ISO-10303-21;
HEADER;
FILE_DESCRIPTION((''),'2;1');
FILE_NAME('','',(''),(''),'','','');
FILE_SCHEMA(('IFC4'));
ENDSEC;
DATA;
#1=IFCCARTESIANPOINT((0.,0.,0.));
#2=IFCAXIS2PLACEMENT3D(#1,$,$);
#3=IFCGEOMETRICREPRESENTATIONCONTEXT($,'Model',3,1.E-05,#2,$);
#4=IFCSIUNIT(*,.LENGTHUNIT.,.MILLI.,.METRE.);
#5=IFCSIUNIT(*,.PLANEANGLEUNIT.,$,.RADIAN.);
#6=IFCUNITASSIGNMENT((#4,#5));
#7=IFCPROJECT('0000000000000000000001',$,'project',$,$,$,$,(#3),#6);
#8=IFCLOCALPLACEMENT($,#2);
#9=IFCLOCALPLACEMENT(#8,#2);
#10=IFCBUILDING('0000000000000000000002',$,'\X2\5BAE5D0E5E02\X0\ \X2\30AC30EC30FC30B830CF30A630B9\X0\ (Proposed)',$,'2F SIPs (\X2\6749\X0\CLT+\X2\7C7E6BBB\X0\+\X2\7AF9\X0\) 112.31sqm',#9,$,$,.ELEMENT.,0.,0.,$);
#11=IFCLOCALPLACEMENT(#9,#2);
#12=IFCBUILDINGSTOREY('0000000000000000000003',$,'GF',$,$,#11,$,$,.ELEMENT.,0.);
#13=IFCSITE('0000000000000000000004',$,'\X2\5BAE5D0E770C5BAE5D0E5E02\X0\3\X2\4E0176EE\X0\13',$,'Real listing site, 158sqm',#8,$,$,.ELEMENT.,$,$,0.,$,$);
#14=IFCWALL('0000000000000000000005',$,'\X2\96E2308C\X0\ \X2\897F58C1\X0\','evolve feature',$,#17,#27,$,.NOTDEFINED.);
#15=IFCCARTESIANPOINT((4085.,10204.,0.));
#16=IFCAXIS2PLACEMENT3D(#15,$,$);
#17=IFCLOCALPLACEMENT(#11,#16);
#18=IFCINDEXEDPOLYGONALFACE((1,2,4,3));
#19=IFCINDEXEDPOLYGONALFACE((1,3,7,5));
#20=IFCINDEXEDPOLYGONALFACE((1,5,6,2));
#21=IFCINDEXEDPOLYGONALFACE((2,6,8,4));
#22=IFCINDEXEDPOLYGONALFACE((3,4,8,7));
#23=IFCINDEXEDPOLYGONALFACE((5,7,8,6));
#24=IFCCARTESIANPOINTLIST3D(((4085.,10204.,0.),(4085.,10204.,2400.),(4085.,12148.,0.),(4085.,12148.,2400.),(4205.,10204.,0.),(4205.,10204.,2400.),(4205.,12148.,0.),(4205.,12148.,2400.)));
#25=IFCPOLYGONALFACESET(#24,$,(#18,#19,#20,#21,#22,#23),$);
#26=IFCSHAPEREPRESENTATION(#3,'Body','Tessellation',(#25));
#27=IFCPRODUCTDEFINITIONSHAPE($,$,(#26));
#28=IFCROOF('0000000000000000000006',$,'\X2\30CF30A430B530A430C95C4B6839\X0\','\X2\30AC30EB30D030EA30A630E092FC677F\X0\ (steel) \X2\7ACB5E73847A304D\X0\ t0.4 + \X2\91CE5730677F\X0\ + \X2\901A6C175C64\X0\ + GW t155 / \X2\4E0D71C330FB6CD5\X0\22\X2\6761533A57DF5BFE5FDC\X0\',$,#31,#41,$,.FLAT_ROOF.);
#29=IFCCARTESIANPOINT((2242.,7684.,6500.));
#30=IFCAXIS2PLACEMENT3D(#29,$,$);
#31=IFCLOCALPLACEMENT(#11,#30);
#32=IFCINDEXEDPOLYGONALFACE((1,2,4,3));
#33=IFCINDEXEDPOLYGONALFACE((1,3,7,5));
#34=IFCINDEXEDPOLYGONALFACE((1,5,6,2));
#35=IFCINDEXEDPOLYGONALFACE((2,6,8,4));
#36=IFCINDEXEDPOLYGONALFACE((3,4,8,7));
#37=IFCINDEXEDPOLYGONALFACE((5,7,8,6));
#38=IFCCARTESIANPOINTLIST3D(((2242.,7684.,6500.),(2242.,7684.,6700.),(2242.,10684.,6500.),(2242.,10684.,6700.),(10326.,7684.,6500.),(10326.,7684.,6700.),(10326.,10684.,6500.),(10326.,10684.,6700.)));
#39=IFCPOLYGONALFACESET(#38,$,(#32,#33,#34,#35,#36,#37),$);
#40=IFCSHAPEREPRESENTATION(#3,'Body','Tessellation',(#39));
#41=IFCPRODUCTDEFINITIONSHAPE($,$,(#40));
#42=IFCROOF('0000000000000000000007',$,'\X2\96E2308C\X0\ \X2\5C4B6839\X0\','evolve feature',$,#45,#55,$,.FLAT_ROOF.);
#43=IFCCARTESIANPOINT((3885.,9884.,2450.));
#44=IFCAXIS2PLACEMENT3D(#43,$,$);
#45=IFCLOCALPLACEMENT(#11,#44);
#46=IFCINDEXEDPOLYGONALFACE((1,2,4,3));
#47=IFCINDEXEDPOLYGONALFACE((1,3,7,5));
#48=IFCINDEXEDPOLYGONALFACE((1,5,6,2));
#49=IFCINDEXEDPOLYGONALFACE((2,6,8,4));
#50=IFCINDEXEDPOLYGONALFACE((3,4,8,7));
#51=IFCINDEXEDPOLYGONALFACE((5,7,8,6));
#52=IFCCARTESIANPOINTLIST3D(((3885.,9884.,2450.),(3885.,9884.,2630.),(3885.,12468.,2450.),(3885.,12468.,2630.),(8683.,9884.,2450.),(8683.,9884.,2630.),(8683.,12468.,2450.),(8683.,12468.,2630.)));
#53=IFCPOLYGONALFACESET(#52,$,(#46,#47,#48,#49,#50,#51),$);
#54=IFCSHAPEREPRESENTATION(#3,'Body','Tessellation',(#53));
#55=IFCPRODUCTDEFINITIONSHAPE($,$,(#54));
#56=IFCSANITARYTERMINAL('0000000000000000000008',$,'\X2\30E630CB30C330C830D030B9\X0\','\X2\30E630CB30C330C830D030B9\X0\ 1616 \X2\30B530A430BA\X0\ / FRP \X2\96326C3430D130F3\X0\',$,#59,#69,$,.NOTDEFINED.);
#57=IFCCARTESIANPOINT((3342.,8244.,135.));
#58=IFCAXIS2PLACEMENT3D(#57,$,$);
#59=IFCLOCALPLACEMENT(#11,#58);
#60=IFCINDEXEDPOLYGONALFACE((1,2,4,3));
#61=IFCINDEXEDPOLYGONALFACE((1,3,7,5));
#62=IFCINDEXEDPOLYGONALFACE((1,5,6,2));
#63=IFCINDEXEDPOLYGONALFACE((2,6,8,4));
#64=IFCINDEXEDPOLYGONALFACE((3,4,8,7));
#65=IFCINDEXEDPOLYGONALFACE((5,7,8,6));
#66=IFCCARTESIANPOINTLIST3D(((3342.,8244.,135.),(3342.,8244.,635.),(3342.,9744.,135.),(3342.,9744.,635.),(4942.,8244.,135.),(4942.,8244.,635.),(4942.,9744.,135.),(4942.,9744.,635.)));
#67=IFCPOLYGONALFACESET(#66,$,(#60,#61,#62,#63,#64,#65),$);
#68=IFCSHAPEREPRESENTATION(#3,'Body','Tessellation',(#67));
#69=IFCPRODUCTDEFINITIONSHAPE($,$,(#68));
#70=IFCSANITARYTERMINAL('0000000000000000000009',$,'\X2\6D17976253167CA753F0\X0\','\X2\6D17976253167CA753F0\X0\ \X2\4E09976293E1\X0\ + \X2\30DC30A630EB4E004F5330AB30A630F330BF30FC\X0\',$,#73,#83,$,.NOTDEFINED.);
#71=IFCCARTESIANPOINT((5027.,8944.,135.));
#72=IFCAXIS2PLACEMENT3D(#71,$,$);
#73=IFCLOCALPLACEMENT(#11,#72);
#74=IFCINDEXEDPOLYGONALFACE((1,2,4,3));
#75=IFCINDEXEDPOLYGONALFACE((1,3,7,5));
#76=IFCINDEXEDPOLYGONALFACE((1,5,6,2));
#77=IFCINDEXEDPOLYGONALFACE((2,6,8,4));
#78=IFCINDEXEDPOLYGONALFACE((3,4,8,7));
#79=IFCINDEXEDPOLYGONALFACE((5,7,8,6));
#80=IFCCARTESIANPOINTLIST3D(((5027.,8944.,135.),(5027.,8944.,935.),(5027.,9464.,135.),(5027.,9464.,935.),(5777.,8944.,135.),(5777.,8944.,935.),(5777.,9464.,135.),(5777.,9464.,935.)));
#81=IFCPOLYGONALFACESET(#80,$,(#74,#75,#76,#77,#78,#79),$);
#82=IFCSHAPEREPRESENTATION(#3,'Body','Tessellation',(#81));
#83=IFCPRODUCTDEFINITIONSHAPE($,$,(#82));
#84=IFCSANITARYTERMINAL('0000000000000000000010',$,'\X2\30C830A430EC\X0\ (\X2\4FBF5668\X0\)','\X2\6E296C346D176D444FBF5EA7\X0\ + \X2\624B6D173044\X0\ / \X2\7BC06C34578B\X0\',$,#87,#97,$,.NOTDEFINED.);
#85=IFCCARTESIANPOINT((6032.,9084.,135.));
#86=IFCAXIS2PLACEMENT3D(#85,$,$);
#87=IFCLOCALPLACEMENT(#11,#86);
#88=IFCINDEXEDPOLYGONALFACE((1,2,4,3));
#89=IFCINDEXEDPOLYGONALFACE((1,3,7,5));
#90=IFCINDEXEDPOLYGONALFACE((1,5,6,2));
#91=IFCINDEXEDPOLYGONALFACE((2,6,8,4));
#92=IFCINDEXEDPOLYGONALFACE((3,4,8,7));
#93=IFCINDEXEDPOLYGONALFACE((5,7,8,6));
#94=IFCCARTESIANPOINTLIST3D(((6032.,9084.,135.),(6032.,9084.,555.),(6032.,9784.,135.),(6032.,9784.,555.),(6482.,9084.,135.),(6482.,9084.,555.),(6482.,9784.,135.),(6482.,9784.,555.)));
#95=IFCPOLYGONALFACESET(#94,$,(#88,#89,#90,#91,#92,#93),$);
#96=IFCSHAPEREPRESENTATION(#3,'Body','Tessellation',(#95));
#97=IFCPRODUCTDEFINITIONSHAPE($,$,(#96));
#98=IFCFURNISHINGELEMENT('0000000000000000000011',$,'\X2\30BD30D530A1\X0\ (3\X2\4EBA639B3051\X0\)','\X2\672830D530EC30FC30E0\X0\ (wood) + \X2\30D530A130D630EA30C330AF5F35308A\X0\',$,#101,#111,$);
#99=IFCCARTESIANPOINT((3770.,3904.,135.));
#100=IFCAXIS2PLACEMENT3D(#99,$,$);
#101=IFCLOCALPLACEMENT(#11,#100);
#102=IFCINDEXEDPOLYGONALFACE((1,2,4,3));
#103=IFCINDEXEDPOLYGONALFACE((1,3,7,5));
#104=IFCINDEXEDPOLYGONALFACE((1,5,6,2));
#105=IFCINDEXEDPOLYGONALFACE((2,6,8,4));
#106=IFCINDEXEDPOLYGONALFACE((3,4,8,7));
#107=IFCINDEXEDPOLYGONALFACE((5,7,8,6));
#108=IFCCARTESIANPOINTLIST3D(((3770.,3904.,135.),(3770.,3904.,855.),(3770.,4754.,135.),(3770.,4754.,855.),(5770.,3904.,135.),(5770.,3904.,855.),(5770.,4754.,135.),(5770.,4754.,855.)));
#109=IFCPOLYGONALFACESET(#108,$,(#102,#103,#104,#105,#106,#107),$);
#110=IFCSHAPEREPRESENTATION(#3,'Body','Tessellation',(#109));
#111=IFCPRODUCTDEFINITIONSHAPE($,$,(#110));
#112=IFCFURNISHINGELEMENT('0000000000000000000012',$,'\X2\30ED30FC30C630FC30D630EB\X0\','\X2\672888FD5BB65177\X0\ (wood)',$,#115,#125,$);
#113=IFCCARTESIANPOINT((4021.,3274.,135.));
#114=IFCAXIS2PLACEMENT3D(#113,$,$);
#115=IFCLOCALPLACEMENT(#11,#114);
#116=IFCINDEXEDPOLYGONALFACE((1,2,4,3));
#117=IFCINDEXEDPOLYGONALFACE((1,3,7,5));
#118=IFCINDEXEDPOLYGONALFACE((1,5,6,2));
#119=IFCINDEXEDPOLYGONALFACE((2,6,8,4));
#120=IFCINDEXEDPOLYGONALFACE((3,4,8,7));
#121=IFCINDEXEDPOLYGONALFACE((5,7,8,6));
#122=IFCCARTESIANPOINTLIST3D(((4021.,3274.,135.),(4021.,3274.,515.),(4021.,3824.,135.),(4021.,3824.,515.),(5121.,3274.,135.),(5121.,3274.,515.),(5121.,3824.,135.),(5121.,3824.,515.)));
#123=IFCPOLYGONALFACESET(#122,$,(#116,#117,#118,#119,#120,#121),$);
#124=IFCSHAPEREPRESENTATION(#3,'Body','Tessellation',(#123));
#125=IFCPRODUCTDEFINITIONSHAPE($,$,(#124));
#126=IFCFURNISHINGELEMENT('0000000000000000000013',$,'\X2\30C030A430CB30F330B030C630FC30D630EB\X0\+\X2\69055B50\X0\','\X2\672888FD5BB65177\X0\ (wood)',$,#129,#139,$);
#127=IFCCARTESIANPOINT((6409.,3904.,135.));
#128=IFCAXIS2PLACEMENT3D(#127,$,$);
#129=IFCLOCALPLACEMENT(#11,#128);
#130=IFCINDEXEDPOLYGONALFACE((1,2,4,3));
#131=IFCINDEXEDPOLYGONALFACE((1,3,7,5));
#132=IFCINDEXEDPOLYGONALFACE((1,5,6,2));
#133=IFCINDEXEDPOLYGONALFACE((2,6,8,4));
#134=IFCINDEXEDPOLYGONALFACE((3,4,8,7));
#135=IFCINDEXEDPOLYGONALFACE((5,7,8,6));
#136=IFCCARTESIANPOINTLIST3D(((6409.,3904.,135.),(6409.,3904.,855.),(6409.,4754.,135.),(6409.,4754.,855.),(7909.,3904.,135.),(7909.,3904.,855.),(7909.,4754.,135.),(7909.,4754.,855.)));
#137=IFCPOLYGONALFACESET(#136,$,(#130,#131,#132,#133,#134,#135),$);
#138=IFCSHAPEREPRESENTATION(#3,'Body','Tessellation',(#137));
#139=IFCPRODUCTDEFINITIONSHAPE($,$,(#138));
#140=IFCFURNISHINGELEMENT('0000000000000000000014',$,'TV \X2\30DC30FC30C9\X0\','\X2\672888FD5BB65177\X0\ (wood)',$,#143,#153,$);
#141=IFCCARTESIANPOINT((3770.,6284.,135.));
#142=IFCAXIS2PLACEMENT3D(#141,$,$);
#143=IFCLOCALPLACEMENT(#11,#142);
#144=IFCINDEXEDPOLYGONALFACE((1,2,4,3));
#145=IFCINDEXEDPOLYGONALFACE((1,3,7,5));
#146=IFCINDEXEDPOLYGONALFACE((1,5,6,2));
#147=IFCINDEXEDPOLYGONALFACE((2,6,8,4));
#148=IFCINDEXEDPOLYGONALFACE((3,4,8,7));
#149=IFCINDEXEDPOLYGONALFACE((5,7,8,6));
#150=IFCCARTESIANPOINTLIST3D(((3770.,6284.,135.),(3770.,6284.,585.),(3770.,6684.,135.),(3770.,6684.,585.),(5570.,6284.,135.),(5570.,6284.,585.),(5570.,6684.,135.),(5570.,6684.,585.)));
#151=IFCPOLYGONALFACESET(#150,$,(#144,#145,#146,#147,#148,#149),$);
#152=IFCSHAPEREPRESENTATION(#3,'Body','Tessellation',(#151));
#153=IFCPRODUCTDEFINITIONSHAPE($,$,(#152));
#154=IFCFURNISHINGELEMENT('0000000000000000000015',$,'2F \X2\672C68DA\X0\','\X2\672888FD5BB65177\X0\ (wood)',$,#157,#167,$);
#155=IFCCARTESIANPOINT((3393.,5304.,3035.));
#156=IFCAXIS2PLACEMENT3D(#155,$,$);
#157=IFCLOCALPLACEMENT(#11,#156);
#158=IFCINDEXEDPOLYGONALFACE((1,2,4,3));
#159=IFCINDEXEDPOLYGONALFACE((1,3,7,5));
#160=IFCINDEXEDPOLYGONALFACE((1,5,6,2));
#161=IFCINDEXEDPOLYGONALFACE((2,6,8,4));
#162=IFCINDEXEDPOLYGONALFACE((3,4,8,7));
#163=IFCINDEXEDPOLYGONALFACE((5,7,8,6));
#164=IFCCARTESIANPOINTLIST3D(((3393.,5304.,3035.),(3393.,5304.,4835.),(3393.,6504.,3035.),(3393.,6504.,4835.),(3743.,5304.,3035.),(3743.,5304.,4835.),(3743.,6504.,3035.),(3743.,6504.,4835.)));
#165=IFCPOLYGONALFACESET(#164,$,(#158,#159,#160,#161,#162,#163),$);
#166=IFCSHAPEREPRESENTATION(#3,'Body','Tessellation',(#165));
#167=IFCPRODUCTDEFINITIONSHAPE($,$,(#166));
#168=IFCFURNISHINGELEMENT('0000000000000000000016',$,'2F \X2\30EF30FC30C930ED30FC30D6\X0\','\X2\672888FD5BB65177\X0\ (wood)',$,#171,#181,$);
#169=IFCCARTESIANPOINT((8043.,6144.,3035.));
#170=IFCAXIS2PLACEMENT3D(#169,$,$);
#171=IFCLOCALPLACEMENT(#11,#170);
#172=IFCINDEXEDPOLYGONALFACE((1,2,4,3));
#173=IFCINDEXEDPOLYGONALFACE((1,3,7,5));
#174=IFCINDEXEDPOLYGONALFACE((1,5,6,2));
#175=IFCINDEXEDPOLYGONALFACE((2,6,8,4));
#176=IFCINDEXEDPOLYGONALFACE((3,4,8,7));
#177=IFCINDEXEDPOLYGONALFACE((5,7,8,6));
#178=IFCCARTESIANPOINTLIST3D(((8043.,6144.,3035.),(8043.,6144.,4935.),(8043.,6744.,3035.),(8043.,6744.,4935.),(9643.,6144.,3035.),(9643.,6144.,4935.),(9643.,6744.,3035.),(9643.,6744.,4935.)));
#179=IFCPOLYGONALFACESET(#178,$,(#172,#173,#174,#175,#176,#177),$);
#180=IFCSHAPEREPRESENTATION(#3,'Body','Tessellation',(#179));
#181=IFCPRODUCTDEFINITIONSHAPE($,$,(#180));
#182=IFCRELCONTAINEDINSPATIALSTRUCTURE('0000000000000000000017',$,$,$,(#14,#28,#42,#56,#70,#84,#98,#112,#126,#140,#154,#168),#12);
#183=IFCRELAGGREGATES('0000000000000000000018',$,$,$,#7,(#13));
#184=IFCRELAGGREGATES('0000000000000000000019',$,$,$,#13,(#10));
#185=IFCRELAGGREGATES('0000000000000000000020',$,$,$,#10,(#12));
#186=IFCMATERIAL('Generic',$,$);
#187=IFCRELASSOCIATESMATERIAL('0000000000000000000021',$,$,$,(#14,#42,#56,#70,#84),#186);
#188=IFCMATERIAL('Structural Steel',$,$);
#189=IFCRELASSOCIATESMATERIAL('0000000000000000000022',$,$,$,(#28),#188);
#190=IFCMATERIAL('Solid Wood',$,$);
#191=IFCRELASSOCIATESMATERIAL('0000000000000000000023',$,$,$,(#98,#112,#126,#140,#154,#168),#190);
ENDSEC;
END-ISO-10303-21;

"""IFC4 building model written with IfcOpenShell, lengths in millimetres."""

from ifc_helpers import new_model, si_unit, frame, frame_2d, origin, place, context, project, spatial, rectangle, extrude, material, element, save


model = new_model("IFC4")

# Units and contexts
model_context = context("Model", 3, precision=1e-05, world=origin())
ifc_project = project(units=[si_unit("LENGTHUNIT", "METRE", prefix="MILLI"), si_unit("PLANEANGLEUNIT", "RADIAN")], contexts=[model_context])

# Site, building, storey
site_placement = place(None, origin())
site = spatial("IfcSite", under=ifc_project, at=site_placement, Name="宮崎県宮崎市3丁目13", ObjectType="Real listing site, 158sqm", CompositionType="ELEMENT", RefElevation=0.0)
building_placement = place(site_placement, origin())
building = spatial("IfcBuilding", under=site, at=building_placement, Name="宮崎市 ガレージハウス (Proposed)", ObjectType="2F SIPs (杉CLT+籾殻+竹) 112.31sqm", CompositionType="ELEMENT", ElevationOfRefHeight=0.0, ElevationOfTerrain=0.0)
storey_placement = place(building_placement, origin())
storey = spatial("IfcBuildingStorey", under=building, at=storey_placement, Name="GF", CompositionType="ELEMENT", Elevation=0.0)

# Shared definitions
ifc_material_1 = material(Name="Generic")

# Shared definitions
ifc_material_2 = material(Name="Solid Wood")

# Wall
wall_1_placement = place(storey_placement, frame((4085.0, 10204.0, 0.0)))
element("IfcWall", 1, at=wall_1_placement, inside=storey, material=ifc_material_1, Name="離れ 西壁", Description="evolve feature", PredefinedType="NOTDEFINED", context=model_context, shape_type="SweptSolid", body=[
    extrude(rectangle(XDim=120.0, YDim=1944.0, at=frame_2d((60.0, 972.0))), frame((4085.0, 10204.0, 0.0)), (0.0, 0.0, 1.0), 2400.0),
])

# Roofs
ifc_material_3 = material(Name="Structural Steel")
roof_1_placement = place(storey_placement, frame((2242.0, 7684.0, 6500.0)))
element("IfcRoof", 2, at=roof_1_placement, inside=storey, material=ifc_material_3, Name="ハイサイド屋根", Description="ガルバリウム鋼板 (steel) 立平葺き t0.4 + 野地板 + 通気層 + GW t155 / 不燃・法22条区域対応", PredefinedType="FLAT_ROOF", context=model_context, shape_type="SweptSolid", body=[
    extrude(rectangle(XDim=8084.0, YDim=3000.0, at=frame_2d((4042.0, 1500.0))), frame((2242.0, 7684.0, 6500.0)), (0.0, 0.0, 1.0), 200.0),
])
roof_2_placement = place(storey_placement, frame((3885.0, 9884.0, 2450.0)))
element("IfcRoof", 3, at=roof_2_placement, inside=storey, material=ifc_material_1, Name="離れ 屋根", Description="evolve feature", PredefinedType="FLAT_ROOF", context=model_context, shape_type="SweptSolid", body=[
    extrude(rectangle(XDim=4798.0, YDim=2584.0, at=frame_2d((2399.0, 1292.0))), frame((3885.0, 9884.0, 2450.0)), (0.0, 0.0, 1.0), 180.0),
])

# Sanitary terminals
sanitary_terminal_1_placement = place(storey_placement, frame((3342.0, 8244.0, 135.0)))
element("IfcSanitaryTerminal", 4, at=sanitary_terminal_1_placement, inside=storey, material=ifc_material_1, Name="ユニットバス", Description="ユニットバス 1616 サイズ / FRP 防水パン", PredefinedType="NOTDEFINED", context=model_context, shape_type="SweptSolid", body=[
    extrude(rectangle(XDim=1600.0, YDim=1500.0, at=frame_2d((800.0, 750.0))), frame((3342.0, 8244.0, 135.0)), (0.0, 0.0, 1.0), 500.0),
])
sanitary_terminal_2_placement = place(storey_placement, frame((5027.0, 8944.0, 135.0)))
element("IfcSanitaryTerminal", 5, at=sanitary_terminal_2_placement, inside=storey, material=ifc_material_1, Name="洗面化粧台", Description="洗面化粧台 三面鏡 + ボウル一体カウンター", PredefinedType="NOTDEFINED", context=model_context, shape_type="SweptSolid", body=[
    extrude(rectangle(XDim=750.0, YDim=520.0, at=frame_2d((375.0, 260.0))), frame((5027.0, 8944.0, 135.0)), (0.0, 0.0, 1.0), 800.0),
])
sanitary_terminal_3_placement = place(storey_placement, frame((6032.0, 9084.0, 135.0)))
element("IfcSanitaryTerminal", 6, at=sanitary_terminal_3_placement, inside=storey, material=ifc_material_1, Name="トイレ (便器)", Description="温水洗浄便座 + 手洗い / 節水型", PredefinedType="NOTDEFINED", context=model_context, shape_type="SweptSolid", body=[
    extrude(rectangle(XDim=450.0, YDim=700.0, at=frame_2d((225.0, 350.0))), frame((6032.0, 9084.0, 135.0)), (0.0, 0.0, 1.0), 420.0),
])

# Furnishing elements
furnishing_1_placement = place(storey_placement, frame((3770.0, 3904.0, 135.0)))
element("IfcFurnishingElement", 7, at=furnishing_1_placement, inside=storey, material=ifc_material_2, Name="ソファ (3人掛け)", Description="木フレーム (wood) + ファブリック張り", context=model_context, shape_type="SweptSolid", body=[
    extrude(rectangle(XDim=2000.0, YDim=850.0, at=frame_2d((1000.0, 425.0))), frame((3770.0, 3904.0, 135.0)), (0.0, 0.0, 1.0), 720.0),
])
furnishing_2_placement = place(storey_placement, frame((4021.0, 3274.0, 135.0)))
element("IfcFurnishingElement", 8, at=furnishing_2_placement, inside=storey, material=ifc_material_2, Name="ローテーブル", Description="木製家具 (wood)", context=model_context, shape_type="SweptSolid", body=[
    extrude(rectangle(XDim=1100.0, YDim=550.0, at=frame_2d((550.0, 275.0))), frame((4021.0, 3274.0, 135.0)), (0.0, 0.0, 1.0), 380.0),
])
furnishing_3_placement = place(storey_placement, frame((6409.0, 3904.0, 135.0)))
element("IfcFurnishingElement", 9, at=furnishing_3_placement, inside=storey, material=ifc_material_2, Name="ダイニングテーブル+椅子", Description="木製家具 (wood)", context=model_context, shape_type="SweptSolid", body=[
    extrude(rectangle(XDim=1500.0, YDim=850.0, at=frame_2d((750.0, 425.0))), frame((6409.0, 3904.0, 135.0)), (0.0, 0.0, 1.0), 720.0),
])
furnishing_4_placement = place(storey_placement, frame((3770.0, 6284.0, 135.0)))
element("IfcFurnishingElement", 10, at=furnishing_4_placement, inside=storey, material=ifc_material_2, Name="TV ボード", Description="木製家具 (wood)", context=model_context, shape_type="SweptSolid", body=[
    extrude(rectangle(XDim=1800.0, YDim=400.0, at=frame_2d((900.0, 200.0))), frame((3770.0, 6284.0, 135.0)), (0.0, 0.0, 1.0), 450.0),
])
furnishing_5_placement = place(storey_placement, frame((3393.0, 5304.0, 3035.0)))
element("IfcFurnishingElement", 11, at=furnishing_5_placement, inside=storey, material=ifc_material_2, Name="2F 本棚", Description="木製家具 (wood)", context=model_context, shape_type="SweptSolid", body=[
    extrude(rectangle(XDim=350.0, YDim=1200.0, at=frame_2d((175.0, 600.0))), frame((3393.0, 5304.0, 3035.0)), (0.0, 0.0, 1.0), 1800.0),
])
furnishing_6_placement = place(storey_placement, frame((8043.0, 6144.0, 3035.0)))
element("IfcFurnishingElement", 12, at=furnishing_6_placement, inside=storey, material=ifc_material_2, Name="2F ワードローブ", Description="木製家具 (wood)", context=model_context, shape_type="SweptSolid", body=[
    extrude(rectangle(XDim=1600.0, YDim=600.0, at=frame_2d((800.0, 300.0))), frame((8043.0, 6144.0, 3035.0)), (0.0, 0.0, 1.0), 1900.0),
])

save(model, "model.ifc")
